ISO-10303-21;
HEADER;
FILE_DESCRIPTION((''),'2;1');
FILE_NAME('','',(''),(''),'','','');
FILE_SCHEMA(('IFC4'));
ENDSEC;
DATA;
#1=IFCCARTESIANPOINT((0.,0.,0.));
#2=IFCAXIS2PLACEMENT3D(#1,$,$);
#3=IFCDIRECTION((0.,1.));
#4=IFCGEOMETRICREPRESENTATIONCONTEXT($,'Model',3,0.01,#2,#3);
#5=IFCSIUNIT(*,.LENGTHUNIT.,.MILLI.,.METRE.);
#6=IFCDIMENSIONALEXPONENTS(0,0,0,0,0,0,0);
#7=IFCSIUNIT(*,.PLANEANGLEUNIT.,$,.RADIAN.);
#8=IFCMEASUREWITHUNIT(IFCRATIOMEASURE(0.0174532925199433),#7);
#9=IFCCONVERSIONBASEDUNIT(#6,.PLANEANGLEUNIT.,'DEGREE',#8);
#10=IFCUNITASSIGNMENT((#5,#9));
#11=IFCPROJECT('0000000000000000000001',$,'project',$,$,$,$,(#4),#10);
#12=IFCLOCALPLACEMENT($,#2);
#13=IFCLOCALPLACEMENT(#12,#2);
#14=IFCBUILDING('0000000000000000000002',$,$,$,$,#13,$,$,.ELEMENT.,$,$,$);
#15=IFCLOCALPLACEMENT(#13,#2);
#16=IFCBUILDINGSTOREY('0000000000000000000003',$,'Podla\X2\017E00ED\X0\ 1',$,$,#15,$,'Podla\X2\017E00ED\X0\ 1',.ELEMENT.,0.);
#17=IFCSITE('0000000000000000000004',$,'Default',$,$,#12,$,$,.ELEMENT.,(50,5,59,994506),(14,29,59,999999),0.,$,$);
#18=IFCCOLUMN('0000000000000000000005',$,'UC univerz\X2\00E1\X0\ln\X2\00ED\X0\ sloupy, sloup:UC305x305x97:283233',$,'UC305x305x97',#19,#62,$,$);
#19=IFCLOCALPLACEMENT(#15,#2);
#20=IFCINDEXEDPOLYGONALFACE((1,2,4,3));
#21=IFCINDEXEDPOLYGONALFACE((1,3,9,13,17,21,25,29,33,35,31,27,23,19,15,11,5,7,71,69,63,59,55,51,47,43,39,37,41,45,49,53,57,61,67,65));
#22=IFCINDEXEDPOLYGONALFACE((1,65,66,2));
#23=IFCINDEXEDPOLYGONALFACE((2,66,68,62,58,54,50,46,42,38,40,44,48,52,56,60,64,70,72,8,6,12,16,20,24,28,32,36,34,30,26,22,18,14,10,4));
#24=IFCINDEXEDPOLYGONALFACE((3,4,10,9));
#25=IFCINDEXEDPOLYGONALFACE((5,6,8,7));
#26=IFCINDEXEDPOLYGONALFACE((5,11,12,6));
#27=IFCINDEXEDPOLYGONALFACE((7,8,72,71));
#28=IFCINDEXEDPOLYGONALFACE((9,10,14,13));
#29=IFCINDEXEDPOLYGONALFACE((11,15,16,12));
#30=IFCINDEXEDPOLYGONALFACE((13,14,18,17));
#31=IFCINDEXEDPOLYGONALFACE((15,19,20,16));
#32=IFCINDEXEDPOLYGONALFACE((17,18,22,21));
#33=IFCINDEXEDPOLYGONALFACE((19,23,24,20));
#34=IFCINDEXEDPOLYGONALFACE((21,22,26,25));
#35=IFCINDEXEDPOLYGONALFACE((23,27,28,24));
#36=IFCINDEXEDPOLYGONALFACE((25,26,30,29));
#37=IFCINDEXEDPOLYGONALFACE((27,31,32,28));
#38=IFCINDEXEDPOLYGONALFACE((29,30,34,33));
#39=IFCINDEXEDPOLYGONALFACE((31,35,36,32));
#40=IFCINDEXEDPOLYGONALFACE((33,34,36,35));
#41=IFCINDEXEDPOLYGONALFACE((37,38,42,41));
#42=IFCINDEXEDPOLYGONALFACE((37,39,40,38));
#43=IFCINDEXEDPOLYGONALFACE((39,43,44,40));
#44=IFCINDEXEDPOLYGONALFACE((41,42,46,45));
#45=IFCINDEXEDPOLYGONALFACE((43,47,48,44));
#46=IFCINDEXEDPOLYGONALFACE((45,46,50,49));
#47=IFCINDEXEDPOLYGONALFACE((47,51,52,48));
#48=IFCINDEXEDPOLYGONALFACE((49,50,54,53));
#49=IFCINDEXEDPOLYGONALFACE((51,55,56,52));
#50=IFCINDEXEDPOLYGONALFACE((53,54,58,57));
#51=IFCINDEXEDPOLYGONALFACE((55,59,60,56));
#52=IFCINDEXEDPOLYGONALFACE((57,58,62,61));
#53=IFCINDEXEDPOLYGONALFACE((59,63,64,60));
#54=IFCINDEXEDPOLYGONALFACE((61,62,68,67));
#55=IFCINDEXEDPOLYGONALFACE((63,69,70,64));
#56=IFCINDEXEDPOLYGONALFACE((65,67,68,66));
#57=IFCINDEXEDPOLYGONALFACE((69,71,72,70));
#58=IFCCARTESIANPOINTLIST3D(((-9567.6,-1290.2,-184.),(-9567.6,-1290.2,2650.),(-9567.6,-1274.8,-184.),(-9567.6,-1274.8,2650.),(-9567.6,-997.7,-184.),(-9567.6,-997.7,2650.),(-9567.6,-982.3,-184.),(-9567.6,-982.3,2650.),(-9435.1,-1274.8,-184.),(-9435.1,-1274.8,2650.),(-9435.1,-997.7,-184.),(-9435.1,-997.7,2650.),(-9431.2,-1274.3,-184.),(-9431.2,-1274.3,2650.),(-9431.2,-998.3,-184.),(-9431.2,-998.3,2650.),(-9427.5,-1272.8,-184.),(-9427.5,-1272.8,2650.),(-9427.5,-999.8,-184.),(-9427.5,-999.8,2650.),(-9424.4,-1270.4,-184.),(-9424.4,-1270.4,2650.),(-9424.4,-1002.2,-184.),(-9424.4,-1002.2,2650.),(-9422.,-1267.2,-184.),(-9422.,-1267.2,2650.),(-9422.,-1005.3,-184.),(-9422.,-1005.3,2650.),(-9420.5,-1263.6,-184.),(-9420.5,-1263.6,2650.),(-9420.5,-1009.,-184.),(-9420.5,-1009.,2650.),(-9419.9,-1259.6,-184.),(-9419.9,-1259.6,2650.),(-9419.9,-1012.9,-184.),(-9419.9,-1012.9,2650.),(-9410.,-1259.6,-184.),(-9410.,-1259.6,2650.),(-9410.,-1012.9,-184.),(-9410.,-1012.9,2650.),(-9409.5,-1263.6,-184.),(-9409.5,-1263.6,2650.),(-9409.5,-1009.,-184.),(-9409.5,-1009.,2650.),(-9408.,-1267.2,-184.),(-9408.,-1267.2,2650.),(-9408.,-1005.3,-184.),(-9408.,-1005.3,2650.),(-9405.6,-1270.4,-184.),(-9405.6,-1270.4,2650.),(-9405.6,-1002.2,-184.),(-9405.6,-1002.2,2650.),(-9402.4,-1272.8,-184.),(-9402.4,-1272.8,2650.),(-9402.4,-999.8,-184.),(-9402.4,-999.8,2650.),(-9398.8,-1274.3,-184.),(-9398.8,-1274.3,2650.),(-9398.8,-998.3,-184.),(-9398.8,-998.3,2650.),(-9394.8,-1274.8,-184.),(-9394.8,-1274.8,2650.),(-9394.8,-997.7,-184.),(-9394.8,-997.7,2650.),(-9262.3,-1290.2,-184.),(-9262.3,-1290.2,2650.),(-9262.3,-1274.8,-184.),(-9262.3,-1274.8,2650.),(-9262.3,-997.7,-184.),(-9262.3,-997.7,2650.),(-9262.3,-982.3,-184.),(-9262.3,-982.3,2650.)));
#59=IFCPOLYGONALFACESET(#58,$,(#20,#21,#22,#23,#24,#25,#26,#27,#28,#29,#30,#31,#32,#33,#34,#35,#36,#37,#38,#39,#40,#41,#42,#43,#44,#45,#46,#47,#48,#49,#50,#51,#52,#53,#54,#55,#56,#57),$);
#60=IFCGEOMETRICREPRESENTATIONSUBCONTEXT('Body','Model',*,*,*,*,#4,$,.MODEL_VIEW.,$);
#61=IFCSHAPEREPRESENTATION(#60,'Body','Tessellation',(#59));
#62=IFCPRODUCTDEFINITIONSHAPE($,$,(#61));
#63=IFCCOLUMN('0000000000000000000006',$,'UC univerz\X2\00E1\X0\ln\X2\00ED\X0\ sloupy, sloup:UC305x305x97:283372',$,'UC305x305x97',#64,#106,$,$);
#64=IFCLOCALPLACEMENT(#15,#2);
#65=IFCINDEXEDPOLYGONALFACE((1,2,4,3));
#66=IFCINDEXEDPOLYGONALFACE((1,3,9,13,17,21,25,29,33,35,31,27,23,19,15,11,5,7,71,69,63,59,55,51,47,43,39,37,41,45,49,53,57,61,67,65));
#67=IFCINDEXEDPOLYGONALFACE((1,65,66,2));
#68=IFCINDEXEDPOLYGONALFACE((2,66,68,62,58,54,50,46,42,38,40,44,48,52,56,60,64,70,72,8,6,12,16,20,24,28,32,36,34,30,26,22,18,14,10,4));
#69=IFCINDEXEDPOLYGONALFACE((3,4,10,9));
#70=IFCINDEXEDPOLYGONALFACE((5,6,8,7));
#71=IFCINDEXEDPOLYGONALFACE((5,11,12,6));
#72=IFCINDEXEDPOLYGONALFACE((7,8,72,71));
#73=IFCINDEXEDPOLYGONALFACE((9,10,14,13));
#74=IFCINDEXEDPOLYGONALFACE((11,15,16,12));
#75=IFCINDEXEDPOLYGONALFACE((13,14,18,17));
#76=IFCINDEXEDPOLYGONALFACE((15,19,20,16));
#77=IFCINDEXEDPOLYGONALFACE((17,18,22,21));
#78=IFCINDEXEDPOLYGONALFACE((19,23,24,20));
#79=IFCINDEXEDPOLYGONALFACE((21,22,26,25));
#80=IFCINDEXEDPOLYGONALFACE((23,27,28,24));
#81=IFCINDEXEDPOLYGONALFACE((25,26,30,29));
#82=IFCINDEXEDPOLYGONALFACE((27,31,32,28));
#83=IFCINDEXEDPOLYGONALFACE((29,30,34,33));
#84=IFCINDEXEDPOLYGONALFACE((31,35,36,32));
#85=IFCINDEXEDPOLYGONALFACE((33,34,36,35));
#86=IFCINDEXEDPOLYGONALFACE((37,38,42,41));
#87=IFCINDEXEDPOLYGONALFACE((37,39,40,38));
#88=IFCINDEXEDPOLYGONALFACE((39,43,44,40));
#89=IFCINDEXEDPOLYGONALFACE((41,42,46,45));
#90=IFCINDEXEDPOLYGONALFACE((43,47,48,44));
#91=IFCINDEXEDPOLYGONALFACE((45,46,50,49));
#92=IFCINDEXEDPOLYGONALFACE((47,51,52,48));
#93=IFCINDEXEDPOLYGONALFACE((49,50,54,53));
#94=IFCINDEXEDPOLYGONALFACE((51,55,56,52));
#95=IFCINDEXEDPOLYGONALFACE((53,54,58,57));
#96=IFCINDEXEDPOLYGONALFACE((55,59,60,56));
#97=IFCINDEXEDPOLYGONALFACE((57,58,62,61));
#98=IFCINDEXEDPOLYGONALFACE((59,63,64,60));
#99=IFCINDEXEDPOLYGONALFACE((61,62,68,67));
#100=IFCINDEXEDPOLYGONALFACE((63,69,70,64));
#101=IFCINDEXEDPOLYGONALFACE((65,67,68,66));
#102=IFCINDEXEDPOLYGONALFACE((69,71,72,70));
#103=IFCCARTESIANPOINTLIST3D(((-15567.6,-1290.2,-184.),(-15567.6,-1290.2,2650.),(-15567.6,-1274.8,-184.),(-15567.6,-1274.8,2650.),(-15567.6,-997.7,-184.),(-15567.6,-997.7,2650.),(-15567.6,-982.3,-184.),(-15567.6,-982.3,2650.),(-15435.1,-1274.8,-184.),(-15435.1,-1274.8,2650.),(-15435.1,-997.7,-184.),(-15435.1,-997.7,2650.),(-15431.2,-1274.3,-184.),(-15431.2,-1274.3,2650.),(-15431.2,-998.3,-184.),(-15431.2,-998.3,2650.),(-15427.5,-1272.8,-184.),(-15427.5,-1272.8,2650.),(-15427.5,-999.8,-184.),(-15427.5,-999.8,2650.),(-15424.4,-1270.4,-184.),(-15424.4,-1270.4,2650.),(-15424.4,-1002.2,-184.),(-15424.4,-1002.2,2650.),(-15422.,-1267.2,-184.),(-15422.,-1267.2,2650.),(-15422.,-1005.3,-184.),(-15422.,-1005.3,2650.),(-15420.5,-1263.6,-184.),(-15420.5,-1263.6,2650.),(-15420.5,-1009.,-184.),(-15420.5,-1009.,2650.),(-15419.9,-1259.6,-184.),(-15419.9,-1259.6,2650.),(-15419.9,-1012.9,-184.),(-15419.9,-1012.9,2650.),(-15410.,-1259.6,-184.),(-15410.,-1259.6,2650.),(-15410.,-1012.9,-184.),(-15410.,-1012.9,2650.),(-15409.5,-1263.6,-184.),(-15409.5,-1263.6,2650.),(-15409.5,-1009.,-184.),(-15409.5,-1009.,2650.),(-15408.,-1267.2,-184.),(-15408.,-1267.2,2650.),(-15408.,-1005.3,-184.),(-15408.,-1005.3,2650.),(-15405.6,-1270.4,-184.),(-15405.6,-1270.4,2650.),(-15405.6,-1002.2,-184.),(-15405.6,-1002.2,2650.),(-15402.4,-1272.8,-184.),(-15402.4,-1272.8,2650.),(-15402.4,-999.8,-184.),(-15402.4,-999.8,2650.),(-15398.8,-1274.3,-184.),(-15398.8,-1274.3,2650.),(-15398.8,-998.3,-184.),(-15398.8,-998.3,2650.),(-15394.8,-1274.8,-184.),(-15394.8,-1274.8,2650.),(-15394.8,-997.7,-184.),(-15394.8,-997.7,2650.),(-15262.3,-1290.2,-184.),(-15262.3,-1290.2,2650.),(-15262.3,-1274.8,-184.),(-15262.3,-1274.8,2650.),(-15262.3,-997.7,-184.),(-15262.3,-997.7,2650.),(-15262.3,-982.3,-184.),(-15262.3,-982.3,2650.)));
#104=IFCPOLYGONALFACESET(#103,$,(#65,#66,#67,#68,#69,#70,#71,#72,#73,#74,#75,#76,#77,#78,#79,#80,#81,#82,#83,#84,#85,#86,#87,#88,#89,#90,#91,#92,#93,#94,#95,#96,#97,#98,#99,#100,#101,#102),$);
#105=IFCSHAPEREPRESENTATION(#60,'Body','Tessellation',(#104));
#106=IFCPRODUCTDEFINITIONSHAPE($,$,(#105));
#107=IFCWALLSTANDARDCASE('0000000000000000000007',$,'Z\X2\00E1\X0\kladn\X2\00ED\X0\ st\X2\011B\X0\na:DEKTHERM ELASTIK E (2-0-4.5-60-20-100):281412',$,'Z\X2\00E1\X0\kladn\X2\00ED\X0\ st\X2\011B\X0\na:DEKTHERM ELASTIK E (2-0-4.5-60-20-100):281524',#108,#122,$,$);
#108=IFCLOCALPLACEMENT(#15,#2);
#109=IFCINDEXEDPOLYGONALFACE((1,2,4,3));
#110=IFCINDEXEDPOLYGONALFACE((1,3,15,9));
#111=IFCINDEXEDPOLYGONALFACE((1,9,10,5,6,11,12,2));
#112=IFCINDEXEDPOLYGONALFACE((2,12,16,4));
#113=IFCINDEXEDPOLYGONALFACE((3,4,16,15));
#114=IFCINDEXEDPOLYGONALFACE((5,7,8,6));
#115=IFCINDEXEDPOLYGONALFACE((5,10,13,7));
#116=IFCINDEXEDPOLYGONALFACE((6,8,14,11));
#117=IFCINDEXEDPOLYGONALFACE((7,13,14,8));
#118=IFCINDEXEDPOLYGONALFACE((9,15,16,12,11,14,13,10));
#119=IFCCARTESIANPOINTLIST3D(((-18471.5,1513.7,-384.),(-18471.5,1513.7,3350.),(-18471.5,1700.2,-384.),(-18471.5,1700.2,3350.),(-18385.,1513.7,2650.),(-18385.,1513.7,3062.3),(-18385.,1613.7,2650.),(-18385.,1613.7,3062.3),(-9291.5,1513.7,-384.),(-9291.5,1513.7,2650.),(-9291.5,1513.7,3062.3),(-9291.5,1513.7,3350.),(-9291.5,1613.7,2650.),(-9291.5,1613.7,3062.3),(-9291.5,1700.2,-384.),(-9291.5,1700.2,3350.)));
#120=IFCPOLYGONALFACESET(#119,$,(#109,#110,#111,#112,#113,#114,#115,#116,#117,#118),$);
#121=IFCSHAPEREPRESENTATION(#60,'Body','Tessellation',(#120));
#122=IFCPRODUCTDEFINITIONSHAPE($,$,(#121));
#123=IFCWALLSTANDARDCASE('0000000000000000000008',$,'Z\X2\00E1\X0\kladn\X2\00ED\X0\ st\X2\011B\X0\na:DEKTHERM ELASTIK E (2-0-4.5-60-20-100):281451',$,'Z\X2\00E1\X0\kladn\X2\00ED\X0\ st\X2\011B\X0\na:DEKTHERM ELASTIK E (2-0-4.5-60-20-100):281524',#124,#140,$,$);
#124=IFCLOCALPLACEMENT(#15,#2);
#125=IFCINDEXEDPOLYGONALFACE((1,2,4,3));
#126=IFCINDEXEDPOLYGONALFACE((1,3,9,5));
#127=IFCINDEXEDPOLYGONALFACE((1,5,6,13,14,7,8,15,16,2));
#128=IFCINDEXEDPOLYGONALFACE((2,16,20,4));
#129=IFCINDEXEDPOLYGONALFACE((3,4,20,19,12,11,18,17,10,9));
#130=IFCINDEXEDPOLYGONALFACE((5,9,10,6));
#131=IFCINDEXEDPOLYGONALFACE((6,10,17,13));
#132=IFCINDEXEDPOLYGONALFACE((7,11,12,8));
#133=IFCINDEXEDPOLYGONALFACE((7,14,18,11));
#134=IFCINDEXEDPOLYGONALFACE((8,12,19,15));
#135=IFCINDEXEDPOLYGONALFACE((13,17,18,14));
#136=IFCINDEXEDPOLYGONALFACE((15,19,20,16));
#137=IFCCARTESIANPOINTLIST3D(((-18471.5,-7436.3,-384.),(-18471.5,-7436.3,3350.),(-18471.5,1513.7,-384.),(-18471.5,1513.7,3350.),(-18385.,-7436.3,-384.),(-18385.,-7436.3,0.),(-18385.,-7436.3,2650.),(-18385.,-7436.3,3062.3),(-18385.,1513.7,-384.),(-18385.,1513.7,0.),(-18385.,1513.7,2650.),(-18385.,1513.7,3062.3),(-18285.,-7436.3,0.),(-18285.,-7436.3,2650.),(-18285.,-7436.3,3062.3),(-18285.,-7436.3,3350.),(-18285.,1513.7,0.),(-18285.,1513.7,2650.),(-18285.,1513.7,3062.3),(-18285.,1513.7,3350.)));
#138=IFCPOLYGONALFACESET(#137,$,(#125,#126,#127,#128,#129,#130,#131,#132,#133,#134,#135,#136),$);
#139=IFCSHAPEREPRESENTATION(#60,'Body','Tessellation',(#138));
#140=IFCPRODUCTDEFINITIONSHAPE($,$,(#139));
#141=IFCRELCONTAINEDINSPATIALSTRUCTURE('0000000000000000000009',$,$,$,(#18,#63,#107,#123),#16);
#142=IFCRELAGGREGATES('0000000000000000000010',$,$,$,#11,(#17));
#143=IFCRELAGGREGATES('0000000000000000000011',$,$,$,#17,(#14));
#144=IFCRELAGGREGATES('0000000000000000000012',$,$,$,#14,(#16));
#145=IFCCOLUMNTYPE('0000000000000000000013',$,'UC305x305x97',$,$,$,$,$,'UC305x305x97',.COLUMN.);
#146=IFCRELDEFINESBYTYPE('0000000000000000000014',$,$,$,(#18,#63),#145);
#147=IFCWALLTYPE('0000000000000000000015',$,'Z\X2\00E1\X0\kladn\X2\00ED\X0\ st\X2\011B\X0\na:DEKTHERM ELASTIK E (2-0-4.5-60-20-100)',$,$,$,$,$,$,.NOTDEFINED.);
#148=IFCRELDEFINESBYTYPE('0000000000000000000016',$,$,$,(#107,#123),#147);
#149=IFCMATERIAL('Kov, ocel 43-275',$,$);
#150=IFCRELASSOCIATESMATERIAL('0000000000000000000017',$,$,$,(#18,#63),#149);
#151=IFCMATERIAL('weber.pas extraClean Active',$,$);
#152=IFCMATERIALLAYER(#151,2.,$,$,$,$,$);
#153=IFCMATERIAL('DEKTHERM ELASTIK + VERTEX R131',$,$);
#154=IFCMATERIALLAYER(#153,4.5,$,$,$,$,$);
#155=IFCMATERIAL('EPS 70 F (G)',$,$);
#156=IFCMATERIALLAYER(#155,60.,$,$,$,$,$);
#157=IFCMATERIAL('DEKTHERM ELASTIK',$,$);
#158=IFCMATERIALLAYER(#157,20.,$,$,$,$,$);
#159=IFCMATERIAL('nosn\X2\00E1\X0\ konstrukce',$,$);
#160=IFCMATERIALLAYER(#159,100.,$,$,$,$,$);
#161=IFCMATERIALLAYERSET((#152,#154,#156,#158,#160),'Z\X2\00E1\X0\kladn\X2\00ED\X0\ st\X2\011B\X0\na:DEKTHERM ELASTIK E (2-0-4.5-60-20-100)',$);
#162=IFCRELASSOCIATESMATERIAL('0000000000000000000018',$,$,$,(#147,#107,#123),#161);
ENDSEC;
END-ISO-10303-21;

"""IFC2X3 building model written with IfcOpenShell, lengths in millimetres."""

from ifc_helpers import new_model, entity, si_unit, converted_unit, direction, frame, frame_2d, origin, origin_2d_with_axis, place, context, subcontext, project, spatial, polyline, rectangle, i_section, extrude, clip, bounded_halfspace, source, transform, mapped, material, layer, layer_set, layer_usage, type_object, type_shapes, element, save


model = new_model("IFC2X3")

# Units and contexts
model_context = context("Model", 3, precision=0.01, world=origin(), true_north=direction((0.0, 1.0)))
body_context = subcontext(model_context, "Body", "Model", "MODEL_VIEW")
ifc_project = project(units=[si_unit("LENGTHUNIT", "METRE", prefix="MILLI"), converted_unit("PLANEANGLEUNIT", "DEGREE", entity("IfcRatioMeasure", 0.0174532925199433), si_unit("PLANEANGLEUNIT", "RADIAN"), dimensions=[0, 0, 0, 0, 0, 0, 0])], contexts=[model_context])

# Site, building, storey
site_placement = place(None, origin())
site = spatial("IfcSite", under=ifc_project, at=site_placement, Name="Default", CompositionType="ELEMENT", RefLatitude=(50, 5, 59, 994506), RefLongitude=(14, 29, 59, 999999), RefElevation=0.0)
building_placement = place(site_placement, origin())
building = spatial("IfcBuilding", under=site, at=building_placement, CompositionType="ELEMENT")
storey_placement = place(building_placement, origin())
storey = spatial("IfcBuildingStorey", under=building, at=storey_placement, Name="Podlaží 1", LongName="Podlaží 1", CompositionType="ELEMENT", Elevation=0.0)

# Columns
ifc_material_1 = material(Name="Kov, ocel 43-275")
column_type = type_object("IfcColumnType", Name="UC305x305x97", ElementType="UC305x305x97", PredefinedType="COLUMN")
shared_shape_1 = source(origin(), body_context, "Body", "SweptSolid", [
    extrude(i_section(OverallWidth=305.3, OverallDepth=307.9, WebThickness=9.9, FlangeThickness=15.4, FilletRadius=15.2, at=origin_2d_with_axis()), frame((0.0, 0.0, -184.0), z_axis=(0.0, 0.0, 1.0), x_axis=(-1.0, 0.0, 0.0)), (0.0, 0.0, 1.0), 2834.0),
])
type_shapes(column_type, [shared_shape_1])
for number, where, name in (
    (1, (-9415.0, -1136.3, 0.0), "UC univerzální sloupy, sloup:UC305x305x97:283233"),
    (2, (-15415.0, -1136.3, 0.0), "UC univerzální sloupy, sloup:UC305x305x97:283372"),
):
    element("IfcColumn", number, at=place(storey_placement, frame(where)), inside=storey, type_object=column_type, material=ifc_material_1, Name=name, ObjectType="UC305x305x97", context=body_context, shape_type="MappedRepresentation", body=[
        mapped(shared_shape_1, transform((0.0, 0.0, 0.0), scale=1.0)),
    ])

# Wall, opening
ifc_material_2 = material(Name="weber.pas extraClean Active")
ifc_layer_1 = layer(ifc_material_2, 2.0)
ifc_material_3 = material(Name="DEKTHERM ELASTIK + VERTEX R131")
ifc_layer_2 = layer(ifc_material_3, 4.5)
ifc_material_4 = material(Name="EPS 70 F (G)")
ifc_layer_3 = layer(ifc_material_4, 60.0)
ifc_material_5 = material(Name="DEKTHERM ELASTIK")
ifc_layer_4 = layer(ifc_material_5, 20.0)
ifc_material_6 = material(Name="nosná konstrukce")
ifc_layer_5 = layer(ifc_material_6, 100.0)
ifc_layer_set = layer_set([ifc_layer_1, ifc_layer_2, ifc_layer_3, ifc_layer_4, ifc_layer_5], Name="Základní stěna:DEKTHERM ELASTIK E (2-0-4.5-60-20-100)")
wall_type = type_object("IfcWallType", Name="Základní stěna:DEKTHERM ELASTIK E (2-0-4.5-60-20-100)", PredefinedType="NOTDEFINED", material=ifc_layer_set)
ifc_layer_usage_1 = layer_usage(ifc_layer_set, "AXIS2", "POSITIVE", -93.2)
wall_1_placement = place(storey_placement, frame((-9291.5, 1607.0, -384.0), z_axis=(0.0, 0.0, 1.0), x_axis=(-1.0, 0.0, 0.0)))
wall_1 = element("IfcWallStandardCase", 3, at=wall_1_placement, inside=storey, type_object=wall_type, material=ifc_layer_usage_1, Name="Základní stěna:DEKTHERM ELASTIK E (2-0-4.5-60-20-100):281412", ObjectType="Základní stěna:DEKTHERM ELASTIK E (2-0-4.5-60-20-100):281524", context=body_context, shape_type="SweptSolid", body=[
    extrude(rectangle(XDim=9180.0, YDim=186.5, at=frame_2d((4590.0, 0.0), x_axis=(-1.0, 0.0))), origin(), (0.0, 0.0, 1.0), 3734.0),
])
opening_1_placement = place(storey_placement, frame((-9291.5, 1607.0, -384.0), z_axis=(0.0, 0.0, 1.0), x_axis=(-1.0, 0.0, 0.0)))
element("IfcOpeningElement", 4, at=opening_1_placement, cuts=wall_1, ObjectType="Opening", context=body_context, shape_type="SweptSolid", body=[
    extrude(rectangle(XDim=9093.5, YDim=100.0, at=frame_2d((-889.4, -10.0), x_axis=(1.0, 0.0))), frame((5436.1, 53.2, 3034.0)), (0.0, 0.0, 1.0), 412.3),
])

# Wall
ifc_layer_usage_2 = layer_usage(ifc_layer_set, "AXIS2", "POSITIVE", -93.2)
wall_2_placement = place(storey_placement, frame((-18378.2, 1513.7, -384.0), z_axis=(0.0, 0.0, 1.0), x_axis=(0.0, -1.0, 0.0)))
element("IfcWallStandardCase", 5, at=wall_2_placement, inside=storey, type_object=wall_type, material=ifc_layer_usage_2, Name="Základní stěna:DEKTHERM ELASTIK E (2-0-4.5-60-20-100):281451", ObjectType="Základní stěna:DEKTHERM ELASTIK E (2-0-4.5-60-20-100):281524", context=body_context, shape_type="Clipping", body=[
    clip(clip(clip(extrude(rectangle(XDim=8950.0, YDim=186.5, at=frame_2d((4475.0, 0.0), x_axis=(-1.0, 0.0))), origin(), (0.0, 0.0, 1.0), 3734.0), bounded_halfspace(frame((0.0, -6.8, 3446.3), z_axis=(0.0, -1.0, 0.0), x_axis=(1.0, 0.0, 0.0)), True, frame((0.0, -6.8, 3446.3), z_axis=(0.0, -1.0, 0.0), x_axis=(1.0, 0.0, 0.0)), polyline([(0.0, 0.0), (0.0, -0.8), (0.0, -412.3), (8950.0, -412.3), (8950.0, -0.8), (8950.0, 0.0), (0.0, 0.0)]))), bounded_halfspace(frame((8950.0, -6.8, 384.0), z_axis=(0.0, 0.0, 1.0), x_axis=(0.0, -1.0, 0.0)), True, frame((8950.0, -6.8, 384.0), z_axis=(0.0, 0.0, 1.0), x_axis=(0.0, -1.0, 0.0)), polyline([(0.0, 0.0), (-100.0, 0.0), (-100.0, -8950.0), (0.0, -8950.0), (0.0, 0.0)]))), bounded_halfspace(frame((0.0, -6.8, 384.0), z_axis=(0.0, -1.0, 0.0), x_axis=(0.0, 0.0, 1.0)), True, frame((0.0, -6.8, 384.0), z_axis=(0.0, -1.0, 0.0), x_axis=(0.0, 0.0, 1.0)), polyline([(0.0, 0.0), (-384.0, 0.0), (-384.0, -8950.0), (0.0, -8950.0), (0.0, 0.0)]))),
])

save(model, "model.ifc")
